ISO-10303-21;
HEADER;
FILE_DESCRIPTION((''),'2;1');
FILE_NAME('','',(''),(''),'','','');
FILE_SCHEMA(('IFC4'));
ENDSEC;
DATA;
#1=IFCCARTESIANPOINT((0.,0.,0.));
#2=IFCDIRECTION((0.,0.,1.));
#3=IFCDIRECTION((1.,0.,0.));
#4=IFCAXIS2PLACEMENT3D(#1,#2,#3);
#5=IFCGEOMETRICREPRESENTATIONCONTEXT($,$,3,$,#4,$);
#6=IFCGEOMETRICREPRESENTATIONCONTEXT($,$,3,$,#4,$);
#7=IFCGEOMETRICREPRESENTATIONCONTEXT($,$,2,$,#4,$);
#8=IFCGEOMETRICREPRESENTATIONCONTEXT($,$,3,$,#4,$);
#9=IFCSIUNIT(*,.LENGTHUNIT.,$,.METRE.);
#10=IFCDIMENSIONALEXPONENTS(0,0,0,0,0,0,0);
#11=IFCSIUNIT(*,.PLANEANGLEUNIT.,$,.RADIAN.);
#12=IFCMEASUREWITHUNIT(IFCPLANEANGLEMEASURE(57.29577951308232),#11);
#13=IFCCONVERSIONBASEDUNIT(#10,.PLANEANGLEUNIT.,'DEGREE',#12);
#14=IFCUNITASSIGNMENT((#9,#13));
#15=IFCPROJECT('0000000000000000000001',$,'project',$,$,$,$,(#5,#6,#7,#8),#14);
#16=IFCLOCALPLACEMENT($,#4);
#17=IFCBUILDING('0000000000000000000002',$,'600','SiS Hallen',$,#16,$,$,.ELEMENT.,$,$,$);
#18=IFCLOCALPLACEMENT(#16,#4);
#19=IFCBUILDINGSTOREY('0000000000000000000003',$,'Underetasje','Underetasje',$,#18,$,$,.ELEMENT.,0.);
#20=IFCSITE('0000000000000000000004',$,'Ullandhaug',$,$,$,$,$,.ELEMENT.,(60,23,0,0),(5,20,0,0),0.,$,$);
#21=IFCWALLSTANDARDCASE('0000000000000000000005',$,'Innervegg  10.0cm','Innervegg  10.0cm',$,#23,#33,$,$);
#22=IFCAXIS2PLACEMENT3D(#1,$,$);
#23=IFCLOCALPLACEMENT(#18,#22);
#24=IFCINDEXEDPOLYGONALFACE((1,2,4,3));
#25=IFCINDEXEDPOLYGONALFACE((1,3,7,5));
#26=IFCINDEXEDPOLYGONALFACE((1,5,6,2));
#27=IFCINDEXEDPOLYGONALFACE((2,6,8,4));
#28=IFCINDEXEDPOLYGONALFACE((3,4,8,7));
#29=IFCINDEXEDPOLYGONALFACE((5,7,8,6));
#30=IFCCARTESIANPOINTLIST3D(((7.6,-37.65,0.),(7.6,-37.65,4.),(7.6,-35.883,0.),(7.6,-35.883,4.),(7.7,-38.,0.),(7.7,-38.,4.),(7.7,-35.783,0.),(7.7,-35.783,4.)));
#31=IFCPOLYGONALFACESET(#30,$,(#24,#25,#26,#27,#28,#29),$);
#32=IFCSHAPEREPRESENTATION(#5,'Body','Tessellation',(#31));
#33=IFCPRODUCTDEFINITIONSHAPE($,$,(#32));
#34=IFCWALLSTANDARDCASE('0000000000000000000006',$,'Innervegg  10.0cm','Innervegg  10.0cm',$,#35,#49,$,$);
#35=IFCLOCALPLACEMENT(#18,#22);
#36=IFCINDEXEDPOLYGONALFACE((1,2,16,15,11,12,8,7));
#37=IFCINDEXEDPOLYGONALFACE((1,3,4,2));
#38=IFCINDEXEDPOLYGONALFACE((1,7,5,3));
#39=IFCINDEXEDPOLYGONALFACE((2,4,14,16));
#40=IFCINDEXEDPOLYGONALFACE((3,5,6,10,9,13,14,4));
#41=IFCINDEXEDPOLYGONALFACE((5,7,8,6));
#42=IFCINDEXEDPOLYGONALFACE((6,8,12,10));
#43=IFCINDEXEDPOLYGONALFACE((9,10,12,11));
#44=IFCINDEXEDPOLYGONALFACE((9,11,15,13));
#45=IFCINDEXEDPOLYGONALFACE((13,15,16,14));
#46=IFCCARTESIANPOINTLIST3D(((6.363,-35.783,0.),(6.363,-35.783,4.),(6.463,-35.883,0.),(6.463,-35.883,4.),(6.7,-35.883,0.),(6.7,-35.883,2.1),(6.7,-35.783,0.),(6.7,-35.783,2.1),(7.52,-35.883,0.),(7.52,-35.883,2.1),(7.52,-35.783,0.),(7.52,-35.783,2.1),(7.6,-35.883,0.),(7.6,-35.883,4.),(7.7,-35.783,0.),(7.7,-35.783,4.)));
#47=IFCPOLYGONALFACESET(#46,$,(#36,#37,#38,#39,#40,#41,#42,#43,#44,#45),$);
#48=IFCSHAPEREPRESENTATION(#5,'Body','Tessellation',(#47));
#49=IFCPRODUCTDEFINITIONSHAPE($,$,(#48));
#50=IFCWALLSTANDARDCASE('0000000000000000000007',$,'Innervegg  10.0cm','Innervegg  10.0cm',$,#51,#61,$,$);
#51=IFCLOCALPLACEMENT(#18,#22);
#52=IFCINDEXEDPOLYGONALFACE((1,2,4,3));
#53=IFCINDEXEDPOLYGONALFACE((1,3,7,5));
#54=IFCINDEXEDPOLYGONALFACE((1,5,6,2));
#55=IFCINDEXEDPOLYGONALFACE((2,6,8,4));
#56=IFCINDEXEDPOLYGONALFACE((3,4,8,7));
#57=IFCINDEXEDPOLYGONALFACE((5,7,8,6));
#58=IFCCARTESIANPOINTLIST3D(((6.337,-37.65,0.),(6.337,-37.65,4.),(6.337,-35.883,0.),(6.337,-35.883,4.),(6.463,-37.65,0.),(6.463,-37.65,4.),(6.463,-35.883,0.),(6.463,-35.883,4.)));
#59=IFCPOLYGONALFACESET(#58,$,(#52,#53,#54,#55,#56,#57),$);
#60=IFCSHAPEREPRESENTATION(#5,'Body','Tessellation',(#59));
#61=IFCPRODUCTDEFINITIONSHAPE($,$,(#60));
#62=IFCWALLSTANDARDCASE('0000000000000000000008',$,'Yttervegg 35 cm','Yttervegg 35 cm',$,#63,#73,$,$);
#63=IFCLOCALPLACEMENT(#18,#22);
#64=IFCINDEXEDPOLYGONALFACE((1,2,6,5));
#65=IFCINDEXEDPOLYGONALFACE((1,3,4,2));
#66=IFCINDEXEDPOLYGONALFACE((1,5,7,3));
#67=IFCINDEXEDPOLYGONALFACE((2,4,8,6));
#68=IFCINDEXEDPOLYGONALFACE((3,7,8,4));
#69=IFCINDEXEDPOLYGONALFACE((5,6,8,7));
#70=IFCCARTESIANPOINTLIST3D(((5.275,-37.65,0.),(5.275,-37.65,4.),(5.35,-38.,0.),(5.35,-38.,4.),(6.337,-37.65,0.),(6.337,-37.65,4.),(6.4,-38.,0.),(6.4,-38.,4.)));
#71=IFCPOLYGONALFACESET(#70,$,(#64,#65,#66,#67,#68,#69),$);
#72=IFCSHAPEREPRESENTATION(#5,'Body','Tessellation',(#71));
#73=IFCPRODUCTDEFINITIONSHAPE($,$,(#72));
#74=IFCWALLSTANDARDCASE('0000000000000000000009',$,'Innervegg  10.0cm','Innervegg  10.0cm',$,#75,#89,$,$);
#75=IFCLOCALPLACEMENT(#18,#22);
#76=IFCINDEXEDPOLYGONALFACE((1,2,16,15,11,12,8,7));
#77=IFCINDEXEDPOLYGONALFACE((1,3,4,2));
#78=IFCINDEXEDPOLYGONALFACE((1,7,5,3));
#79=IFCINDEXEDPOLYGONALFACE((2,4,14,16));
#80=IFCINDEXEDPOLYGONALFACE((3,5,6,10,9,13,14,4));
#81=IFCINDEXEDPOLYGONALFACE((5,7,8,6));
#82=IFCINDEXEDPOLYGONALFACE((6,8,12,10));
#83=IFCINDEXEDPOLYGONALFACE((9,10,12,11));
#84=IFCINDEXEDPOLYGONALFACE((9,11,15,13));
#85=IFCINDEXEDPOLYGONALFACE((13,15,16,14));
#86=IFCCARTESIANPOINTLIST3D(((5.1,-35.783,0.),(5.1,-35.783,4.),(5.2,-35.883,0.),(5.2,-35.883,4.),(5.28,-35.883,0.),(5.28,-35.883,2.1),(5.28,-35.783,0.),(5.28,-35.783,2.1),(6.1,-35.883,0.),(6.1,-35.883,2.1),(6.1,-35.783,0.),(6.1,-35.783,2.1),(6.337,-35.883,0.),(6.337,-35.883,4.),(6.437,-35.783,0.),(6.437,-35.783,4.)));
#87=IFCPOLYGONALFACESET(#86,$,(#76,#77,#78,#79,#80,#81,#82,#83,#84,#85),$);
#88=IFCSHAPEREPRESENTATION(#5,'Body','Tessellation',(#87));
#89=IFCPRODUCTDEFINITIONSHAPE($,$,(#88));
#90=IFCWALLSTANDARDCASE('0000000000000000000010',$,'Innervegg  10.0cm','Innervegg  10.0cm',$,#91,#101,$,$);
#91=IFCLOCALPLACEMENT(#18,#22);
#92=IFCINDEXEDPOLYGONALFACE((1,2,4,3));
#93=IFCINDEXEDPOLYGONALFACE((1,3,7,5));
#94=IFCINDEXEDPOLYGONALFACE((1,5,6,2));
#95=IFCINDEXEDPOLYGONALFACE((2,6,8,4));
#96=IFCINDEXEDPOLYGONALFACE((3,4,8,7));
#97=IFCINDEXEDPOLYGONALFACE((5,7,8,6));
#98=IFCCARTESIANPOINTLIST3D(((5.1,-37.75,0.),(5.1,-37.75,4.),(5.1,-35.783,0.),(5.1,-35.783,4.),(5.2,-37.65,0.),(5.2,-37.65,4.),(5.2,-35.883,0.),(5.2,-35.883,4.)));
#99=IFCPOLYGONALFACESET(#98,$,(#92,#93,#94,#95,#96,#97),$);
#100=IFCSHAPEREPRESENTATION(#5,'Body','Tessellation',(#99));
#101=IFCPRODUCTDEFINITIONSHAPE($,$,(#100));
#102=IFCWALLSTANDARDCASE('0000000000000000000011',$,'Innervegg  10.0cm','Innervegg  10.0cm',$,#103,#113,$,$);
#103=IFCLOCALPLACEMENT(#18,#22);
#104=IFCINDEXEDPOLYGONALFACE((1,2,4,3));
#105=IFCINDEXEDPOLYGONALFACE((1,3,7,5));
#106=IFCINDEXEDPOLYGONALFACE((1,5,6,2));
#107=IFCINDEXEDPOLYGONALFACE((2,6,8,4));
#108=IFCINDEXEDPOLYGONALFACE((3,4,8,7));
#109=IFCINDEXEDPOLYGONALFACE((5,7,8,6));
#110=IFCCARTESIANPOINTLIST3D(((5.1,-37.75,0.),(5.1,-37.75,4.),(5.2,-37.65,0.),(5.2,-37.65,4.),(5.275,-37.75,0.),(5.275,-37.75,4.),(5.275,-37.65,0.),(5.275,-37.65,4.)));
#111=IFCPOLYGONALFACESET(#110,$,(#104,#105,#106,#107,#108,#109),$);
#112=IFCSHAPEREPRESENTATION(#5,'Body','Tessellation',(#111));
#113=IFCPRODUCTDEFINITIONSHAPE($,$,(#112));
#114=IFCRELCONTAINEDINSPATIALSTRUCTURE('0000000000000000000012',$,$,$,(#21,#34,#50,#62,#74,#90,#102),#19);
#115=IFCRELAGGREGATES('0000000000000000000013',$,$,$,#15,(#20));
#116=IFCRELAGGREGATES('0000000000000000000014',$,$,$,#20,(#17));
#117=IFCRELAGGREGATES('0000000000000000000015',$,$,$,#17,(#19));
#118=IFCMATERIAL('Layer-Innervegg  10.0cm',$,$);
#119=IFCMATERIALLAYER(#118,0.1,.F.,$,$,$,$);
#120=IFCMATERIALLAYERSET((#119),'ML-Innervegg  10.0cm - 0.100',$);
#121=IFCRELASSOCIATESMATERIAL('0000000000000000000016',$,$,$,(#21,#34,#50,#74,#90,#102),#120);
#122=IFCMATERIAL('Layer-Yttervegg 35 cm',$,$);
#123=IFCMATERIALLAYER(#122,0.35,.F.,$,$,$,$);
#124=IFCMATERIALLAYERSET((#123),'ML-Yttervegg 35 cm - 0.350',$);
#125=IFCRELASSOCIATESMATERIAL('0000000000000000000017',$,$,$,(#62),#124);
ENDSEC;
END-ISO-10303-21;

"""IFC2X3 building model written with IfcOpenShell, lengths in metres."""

from ifc_helpers import new_model, entity, si_unit, converted_unit, frame, origin_with_axes, place, context, project, spatial, polyline, outline, extrude, material, layer, layer_set, layer_usage, element, save


model = new_model("IFC2X3")

# Units and contexts
context_of_model_1 = context(None, 3, world=origin_with_axes())
context_of_model_2 = context(None, 3, world=origin_with_axes())
context_of_model_3 = context(None, 2, world=origin_with_axes())
context_of_model_4 = context(None, 3, world=origin_with_axes())
ifc_project = project(units=[si_unit("LENGTHUNIT", "METRE"), converted_unit("PLANEANGLEUNIT", "DEGREE", entity("IfcPlaneAngleMeasure", 57.29577951308232), si_unit("PLANEANGLEUNIT", "RADIAN"), dimensions=[0, 0, 0, 0, 0, 0, 0])], contexts=[context_of_model_1, context_of_model_2, context_of_model_3, context_of_model_4])

# Site, building, storey
site = spatial("IfcSite", under=ifc_project, Name="Ullandhaug", CompositionType="ELEMENT", RefLatitude=(60, 23, 0, 0), RefLongitude=(5, 20, 0, 0), RefElevation=0.0)
building_placement = place(None, origin_with_axes())
building = spatial("IfcBuilding", under=site, at=building_placement, Name="600", Description="SiS Hallen", CompositionType="ELEMENT")
storey_placement = place(building_placement, origin_with_axes())
storey = spatial("IfcBuildingStorey", under=building, at=storey_placement, Name="Underetasje", Description="Underetasje", CompositionType="ELEMENT", Elevation=0.0)

# Wall
ifc_material_1 = material(Name="Layer-Yttervegg 35 cm")
ifc_layer_1 = layer(ifc_material_1, 0.35, ventilated=False)
ifc_layer_set_1 = layer_set([ifc_layer_1], Name="ML-Yttervegg 35 cm - 0.350")
ifc_layer_usage_1 = layer_usage(ifc_layer_set_1, "AXIS2", "POSITIVE", 0.0)
ifc_material_2 = material(Name="Layer-Innervegg  10.0cm")
ifc_layer_2 = layer(ifc_material_2, 0.1, ventilated=False)
ifc_layer_set_2 = layer_set([ifc_layer_2], Name="ML-Innervegg  10.0cm - 0.100")
ifc_layer_usage_2 = layer_usage(ifc_layer_set_2, "AXIS2", "POSITIVE", 0.0)
wall_1_placement = place(storey_placement, frame((7.7, -38.0, 0.0), z_axis=(0.0, 0.0, 1.0), x_axis=(0.0, 1.0, 0.0)))
element("IfcWallStandardCase", 1, at=wall_1_placement, inside=storey, material=ifc_layer_usage_2, Name="Innervegg  10.0cm", Description="Innervegg  10.0cm", context=context_of_model_1, shape_type="SweptSolid", body=[
    extrude(outline(polyline([(0.0, 0.0), (2.217, 0.0), (2.117, 0.1), (0.35, 0.1), (0.0, 0.0)])), frame((0.0, 0.0, 0.0), z_axis=(0.0, 0.0, 1.0), x_axis=(1.0, 0.0, 0.0)), (0.0, 0.0, 1.0), 4.0),
])

# Wall, opening
wall_2_placement = place(storey_placement, frame((7.7, -35.783, 0.0), z_axis=(0.0, 0.0, 1.0), x_axis=(-1.0, 0.0, 0.0)))
wall_2 = element("IfcWallStandardCase", 2, at=wall_2_placement, inside=storey, material=ifc_layer_usage_2, Name="Innervegg  10.0cm", Description="Innervegg  10.0cm", context=context_of_model_1, shape_type="SweptSolid", body=[
    extrude(outline(polyline([(0.0, 0.0), (1.337, 0.0), (1.237, 0.1), (0.1, 0.1), (0.0, 0.0)])), frame((0.0, 0.0, 0.0), z_axis=(0.0, 0.0, 1.0), x_axis=(1.0, 0.0, 0.0)), (0.0, 0.0, 1.0), 4.0),
])
opening_1_placement = place(wall_2_placement, frame((0.18, 0.1, 0.0), z_axis=(0.0, 0.0, 1.0), x_axis=(1.0, 0.0, 0.0)))
element("IfcOpeningElement", 3, at=opening_1_placement, cuts=wall_2, context=context_of_model_1, shape_type="SweptSolid", body=[
    extrude(outline(polyline([(0.0, 0.0), (2.1, 0.0), (2.1, 0.82), (0.0, 0.82), (0.0, 0.0)])), frame((0.0, 0.0, 0.0), z_axis=(0.0, 1.0, 0.0), x_axis=(0.0, 0.0, 1.0)), (0.0, 0.0, -1.0), 0.1),
])

# Walls
wall_3_placement = place(storey_placement, frame((6.337, -35.883, 0.0), z_axis=(0.0, 0.0, 1.0), x_axis=(0.0, -1.0, 0.0)))
element("IfcWallStandardCase", 4, at=wall_3_placement, inside=storey, material=ifc_layer_usage_2, Name="Innervegg  10.0cm", Description="Innervegg  10.0cm", context=context_of_model_1, shape_type="SweptSolid", body=[
    extrude(outline(polyline([(0.0, 0.0), (1.767, 0.0), (1.767, 0.126), (0.0, 0.126), (0.0, 0.0)])), frame((0.0, 0.0, 0.0), z_axis=(0.0, 0.0, 1.0), x_axis=(1.0, 0.0, 0.0)), (0.0, 0.0, 1.0), 4.0),
])
wall_4_placement = place(storey_placement, frame((5.35, -38.0, 0.0), z_axis=(0.0, 0.0, 1.0), x_axis=(1.0, 0.0, 0.0)))
element("IfcWallStandardCase", 5, at=wall_4_placement, inside=storey, material=ifc_layer_usage_1, Name="Yttervegg 35 cm", Description="Yttervegg 35 cm", context=context_of_model_1, shape_type="SweptSolid", body=[
    extrude(outline(polyline([(0.0, 0.0), (1.05, 0.0), (0.987, 0.35), (-0.075, 0.35), (0.0, 0.0)])), origin_with_axes(), (0.0, 0.0, 1.0), 4.0),
])

# Wall, opening
wall_5_placement = place(storey_placement, frame((6.437, -35.783, 0.0), z_axis=(0.0, 0.0, 1.0), x_axis=(-1.0, 0.0, 0.0)))
wall_5 = element("IfcWallStandardCase", 6, at=wall_5_placement, inside=storey, material=ifc_layer_usage_2, Name="Innervegg  10.0cm", Description="Innervegg  10.0cm", context=context_of_model_1, shape_type="SweptSolid", body=[
    extrude(outline(polyline([(0.0, 0.0), (1.337, 0.0), (1.237, 0.1), (0.1, 0.1), (0.0, 0.0)])), frame((0.0, 0.0, 0.0), z_axis=(0.0, 0.0, 1.0), x_axis=(1.0, 0.0, 0.0)), (0.0, 0.0, 1.0), 4.0),
])
opening_2_placement = place(wall_5_placement, frame((0.337, 0.1, 0.0), z_axis=(0.0, 0.0, 1.0), x_axis=(1.0, 0.0, 0.0)))
element("IfcOpeningElement", 7, at=opening_2_placement, cuts=wall_5, context=context_of_model_1, shape_type="SweptSolid", body=[
    extrude(outline(polyline([(0.0, 0.0), (2.1, 0.0), (2.1, 0.82), (0.0, 0.82), (0.0, 0.0)])), frame((0.0, 0.0, 0.0), z_axis=(0.0, 1.0, 0.0), x_axis=(0.0, 0.0, 1.0)), (0.0, 0.0, -1.0), 0.1),
])

# Walls
wall_6_placement = place(storey_placement, frame((5.1, -35.783, 0.0), z_axis=(0.0, 0.0, 1.0), x_axis=(0.0, -1.0, 0.0)))
element("IfcWallStandardCase", 8, at=wall_6_placement, inside=storey, material=ifc_layer_usage_2, Name="Innervegg  10.0cm", Description="Innervegg  10.0cm", context=context_of_model_1, shape_type="SweptSolid", body=[
    extrude(outline(polyline([(0.0, 0.0), (1.967, 0.0), (1.867, 0.1), (0.1, 0.1), (0.0, 0.0)])), frame((0.0, 0.0, 0.0), z_axis=(0.0, 0.0, 1.0), x_axis=(1.0, 0.0, 0.0)), (0.0, 0.0, 1.0), 4.0),
])
wall_7_placement = place(storey_placement, frame((5.1, -37.75, 0.0), z_axis=(0.0, 0.0, 1.0), x_axis=(1.0, 0.0, 0.0)))
element("IfcWallStandardCase", 9, at=wall_7_placement, inside=storey, material=ifc_layer_usage_2, Name="Innervegg  10.0cm", Description="Innervegg  10.0cm", context=context_of_model_1, shape_type="SweptSolid", body=[
    extrude(outline(polyline([(0.0, 0.0), (0.175, 0.0), (0.175, 0.1), (0.1, 0.1), (0.0, 0.0)])), origin_with_axes(), (0.0, 0.0, 1.0), 4.0),
])

save(model, "model.ifc")
